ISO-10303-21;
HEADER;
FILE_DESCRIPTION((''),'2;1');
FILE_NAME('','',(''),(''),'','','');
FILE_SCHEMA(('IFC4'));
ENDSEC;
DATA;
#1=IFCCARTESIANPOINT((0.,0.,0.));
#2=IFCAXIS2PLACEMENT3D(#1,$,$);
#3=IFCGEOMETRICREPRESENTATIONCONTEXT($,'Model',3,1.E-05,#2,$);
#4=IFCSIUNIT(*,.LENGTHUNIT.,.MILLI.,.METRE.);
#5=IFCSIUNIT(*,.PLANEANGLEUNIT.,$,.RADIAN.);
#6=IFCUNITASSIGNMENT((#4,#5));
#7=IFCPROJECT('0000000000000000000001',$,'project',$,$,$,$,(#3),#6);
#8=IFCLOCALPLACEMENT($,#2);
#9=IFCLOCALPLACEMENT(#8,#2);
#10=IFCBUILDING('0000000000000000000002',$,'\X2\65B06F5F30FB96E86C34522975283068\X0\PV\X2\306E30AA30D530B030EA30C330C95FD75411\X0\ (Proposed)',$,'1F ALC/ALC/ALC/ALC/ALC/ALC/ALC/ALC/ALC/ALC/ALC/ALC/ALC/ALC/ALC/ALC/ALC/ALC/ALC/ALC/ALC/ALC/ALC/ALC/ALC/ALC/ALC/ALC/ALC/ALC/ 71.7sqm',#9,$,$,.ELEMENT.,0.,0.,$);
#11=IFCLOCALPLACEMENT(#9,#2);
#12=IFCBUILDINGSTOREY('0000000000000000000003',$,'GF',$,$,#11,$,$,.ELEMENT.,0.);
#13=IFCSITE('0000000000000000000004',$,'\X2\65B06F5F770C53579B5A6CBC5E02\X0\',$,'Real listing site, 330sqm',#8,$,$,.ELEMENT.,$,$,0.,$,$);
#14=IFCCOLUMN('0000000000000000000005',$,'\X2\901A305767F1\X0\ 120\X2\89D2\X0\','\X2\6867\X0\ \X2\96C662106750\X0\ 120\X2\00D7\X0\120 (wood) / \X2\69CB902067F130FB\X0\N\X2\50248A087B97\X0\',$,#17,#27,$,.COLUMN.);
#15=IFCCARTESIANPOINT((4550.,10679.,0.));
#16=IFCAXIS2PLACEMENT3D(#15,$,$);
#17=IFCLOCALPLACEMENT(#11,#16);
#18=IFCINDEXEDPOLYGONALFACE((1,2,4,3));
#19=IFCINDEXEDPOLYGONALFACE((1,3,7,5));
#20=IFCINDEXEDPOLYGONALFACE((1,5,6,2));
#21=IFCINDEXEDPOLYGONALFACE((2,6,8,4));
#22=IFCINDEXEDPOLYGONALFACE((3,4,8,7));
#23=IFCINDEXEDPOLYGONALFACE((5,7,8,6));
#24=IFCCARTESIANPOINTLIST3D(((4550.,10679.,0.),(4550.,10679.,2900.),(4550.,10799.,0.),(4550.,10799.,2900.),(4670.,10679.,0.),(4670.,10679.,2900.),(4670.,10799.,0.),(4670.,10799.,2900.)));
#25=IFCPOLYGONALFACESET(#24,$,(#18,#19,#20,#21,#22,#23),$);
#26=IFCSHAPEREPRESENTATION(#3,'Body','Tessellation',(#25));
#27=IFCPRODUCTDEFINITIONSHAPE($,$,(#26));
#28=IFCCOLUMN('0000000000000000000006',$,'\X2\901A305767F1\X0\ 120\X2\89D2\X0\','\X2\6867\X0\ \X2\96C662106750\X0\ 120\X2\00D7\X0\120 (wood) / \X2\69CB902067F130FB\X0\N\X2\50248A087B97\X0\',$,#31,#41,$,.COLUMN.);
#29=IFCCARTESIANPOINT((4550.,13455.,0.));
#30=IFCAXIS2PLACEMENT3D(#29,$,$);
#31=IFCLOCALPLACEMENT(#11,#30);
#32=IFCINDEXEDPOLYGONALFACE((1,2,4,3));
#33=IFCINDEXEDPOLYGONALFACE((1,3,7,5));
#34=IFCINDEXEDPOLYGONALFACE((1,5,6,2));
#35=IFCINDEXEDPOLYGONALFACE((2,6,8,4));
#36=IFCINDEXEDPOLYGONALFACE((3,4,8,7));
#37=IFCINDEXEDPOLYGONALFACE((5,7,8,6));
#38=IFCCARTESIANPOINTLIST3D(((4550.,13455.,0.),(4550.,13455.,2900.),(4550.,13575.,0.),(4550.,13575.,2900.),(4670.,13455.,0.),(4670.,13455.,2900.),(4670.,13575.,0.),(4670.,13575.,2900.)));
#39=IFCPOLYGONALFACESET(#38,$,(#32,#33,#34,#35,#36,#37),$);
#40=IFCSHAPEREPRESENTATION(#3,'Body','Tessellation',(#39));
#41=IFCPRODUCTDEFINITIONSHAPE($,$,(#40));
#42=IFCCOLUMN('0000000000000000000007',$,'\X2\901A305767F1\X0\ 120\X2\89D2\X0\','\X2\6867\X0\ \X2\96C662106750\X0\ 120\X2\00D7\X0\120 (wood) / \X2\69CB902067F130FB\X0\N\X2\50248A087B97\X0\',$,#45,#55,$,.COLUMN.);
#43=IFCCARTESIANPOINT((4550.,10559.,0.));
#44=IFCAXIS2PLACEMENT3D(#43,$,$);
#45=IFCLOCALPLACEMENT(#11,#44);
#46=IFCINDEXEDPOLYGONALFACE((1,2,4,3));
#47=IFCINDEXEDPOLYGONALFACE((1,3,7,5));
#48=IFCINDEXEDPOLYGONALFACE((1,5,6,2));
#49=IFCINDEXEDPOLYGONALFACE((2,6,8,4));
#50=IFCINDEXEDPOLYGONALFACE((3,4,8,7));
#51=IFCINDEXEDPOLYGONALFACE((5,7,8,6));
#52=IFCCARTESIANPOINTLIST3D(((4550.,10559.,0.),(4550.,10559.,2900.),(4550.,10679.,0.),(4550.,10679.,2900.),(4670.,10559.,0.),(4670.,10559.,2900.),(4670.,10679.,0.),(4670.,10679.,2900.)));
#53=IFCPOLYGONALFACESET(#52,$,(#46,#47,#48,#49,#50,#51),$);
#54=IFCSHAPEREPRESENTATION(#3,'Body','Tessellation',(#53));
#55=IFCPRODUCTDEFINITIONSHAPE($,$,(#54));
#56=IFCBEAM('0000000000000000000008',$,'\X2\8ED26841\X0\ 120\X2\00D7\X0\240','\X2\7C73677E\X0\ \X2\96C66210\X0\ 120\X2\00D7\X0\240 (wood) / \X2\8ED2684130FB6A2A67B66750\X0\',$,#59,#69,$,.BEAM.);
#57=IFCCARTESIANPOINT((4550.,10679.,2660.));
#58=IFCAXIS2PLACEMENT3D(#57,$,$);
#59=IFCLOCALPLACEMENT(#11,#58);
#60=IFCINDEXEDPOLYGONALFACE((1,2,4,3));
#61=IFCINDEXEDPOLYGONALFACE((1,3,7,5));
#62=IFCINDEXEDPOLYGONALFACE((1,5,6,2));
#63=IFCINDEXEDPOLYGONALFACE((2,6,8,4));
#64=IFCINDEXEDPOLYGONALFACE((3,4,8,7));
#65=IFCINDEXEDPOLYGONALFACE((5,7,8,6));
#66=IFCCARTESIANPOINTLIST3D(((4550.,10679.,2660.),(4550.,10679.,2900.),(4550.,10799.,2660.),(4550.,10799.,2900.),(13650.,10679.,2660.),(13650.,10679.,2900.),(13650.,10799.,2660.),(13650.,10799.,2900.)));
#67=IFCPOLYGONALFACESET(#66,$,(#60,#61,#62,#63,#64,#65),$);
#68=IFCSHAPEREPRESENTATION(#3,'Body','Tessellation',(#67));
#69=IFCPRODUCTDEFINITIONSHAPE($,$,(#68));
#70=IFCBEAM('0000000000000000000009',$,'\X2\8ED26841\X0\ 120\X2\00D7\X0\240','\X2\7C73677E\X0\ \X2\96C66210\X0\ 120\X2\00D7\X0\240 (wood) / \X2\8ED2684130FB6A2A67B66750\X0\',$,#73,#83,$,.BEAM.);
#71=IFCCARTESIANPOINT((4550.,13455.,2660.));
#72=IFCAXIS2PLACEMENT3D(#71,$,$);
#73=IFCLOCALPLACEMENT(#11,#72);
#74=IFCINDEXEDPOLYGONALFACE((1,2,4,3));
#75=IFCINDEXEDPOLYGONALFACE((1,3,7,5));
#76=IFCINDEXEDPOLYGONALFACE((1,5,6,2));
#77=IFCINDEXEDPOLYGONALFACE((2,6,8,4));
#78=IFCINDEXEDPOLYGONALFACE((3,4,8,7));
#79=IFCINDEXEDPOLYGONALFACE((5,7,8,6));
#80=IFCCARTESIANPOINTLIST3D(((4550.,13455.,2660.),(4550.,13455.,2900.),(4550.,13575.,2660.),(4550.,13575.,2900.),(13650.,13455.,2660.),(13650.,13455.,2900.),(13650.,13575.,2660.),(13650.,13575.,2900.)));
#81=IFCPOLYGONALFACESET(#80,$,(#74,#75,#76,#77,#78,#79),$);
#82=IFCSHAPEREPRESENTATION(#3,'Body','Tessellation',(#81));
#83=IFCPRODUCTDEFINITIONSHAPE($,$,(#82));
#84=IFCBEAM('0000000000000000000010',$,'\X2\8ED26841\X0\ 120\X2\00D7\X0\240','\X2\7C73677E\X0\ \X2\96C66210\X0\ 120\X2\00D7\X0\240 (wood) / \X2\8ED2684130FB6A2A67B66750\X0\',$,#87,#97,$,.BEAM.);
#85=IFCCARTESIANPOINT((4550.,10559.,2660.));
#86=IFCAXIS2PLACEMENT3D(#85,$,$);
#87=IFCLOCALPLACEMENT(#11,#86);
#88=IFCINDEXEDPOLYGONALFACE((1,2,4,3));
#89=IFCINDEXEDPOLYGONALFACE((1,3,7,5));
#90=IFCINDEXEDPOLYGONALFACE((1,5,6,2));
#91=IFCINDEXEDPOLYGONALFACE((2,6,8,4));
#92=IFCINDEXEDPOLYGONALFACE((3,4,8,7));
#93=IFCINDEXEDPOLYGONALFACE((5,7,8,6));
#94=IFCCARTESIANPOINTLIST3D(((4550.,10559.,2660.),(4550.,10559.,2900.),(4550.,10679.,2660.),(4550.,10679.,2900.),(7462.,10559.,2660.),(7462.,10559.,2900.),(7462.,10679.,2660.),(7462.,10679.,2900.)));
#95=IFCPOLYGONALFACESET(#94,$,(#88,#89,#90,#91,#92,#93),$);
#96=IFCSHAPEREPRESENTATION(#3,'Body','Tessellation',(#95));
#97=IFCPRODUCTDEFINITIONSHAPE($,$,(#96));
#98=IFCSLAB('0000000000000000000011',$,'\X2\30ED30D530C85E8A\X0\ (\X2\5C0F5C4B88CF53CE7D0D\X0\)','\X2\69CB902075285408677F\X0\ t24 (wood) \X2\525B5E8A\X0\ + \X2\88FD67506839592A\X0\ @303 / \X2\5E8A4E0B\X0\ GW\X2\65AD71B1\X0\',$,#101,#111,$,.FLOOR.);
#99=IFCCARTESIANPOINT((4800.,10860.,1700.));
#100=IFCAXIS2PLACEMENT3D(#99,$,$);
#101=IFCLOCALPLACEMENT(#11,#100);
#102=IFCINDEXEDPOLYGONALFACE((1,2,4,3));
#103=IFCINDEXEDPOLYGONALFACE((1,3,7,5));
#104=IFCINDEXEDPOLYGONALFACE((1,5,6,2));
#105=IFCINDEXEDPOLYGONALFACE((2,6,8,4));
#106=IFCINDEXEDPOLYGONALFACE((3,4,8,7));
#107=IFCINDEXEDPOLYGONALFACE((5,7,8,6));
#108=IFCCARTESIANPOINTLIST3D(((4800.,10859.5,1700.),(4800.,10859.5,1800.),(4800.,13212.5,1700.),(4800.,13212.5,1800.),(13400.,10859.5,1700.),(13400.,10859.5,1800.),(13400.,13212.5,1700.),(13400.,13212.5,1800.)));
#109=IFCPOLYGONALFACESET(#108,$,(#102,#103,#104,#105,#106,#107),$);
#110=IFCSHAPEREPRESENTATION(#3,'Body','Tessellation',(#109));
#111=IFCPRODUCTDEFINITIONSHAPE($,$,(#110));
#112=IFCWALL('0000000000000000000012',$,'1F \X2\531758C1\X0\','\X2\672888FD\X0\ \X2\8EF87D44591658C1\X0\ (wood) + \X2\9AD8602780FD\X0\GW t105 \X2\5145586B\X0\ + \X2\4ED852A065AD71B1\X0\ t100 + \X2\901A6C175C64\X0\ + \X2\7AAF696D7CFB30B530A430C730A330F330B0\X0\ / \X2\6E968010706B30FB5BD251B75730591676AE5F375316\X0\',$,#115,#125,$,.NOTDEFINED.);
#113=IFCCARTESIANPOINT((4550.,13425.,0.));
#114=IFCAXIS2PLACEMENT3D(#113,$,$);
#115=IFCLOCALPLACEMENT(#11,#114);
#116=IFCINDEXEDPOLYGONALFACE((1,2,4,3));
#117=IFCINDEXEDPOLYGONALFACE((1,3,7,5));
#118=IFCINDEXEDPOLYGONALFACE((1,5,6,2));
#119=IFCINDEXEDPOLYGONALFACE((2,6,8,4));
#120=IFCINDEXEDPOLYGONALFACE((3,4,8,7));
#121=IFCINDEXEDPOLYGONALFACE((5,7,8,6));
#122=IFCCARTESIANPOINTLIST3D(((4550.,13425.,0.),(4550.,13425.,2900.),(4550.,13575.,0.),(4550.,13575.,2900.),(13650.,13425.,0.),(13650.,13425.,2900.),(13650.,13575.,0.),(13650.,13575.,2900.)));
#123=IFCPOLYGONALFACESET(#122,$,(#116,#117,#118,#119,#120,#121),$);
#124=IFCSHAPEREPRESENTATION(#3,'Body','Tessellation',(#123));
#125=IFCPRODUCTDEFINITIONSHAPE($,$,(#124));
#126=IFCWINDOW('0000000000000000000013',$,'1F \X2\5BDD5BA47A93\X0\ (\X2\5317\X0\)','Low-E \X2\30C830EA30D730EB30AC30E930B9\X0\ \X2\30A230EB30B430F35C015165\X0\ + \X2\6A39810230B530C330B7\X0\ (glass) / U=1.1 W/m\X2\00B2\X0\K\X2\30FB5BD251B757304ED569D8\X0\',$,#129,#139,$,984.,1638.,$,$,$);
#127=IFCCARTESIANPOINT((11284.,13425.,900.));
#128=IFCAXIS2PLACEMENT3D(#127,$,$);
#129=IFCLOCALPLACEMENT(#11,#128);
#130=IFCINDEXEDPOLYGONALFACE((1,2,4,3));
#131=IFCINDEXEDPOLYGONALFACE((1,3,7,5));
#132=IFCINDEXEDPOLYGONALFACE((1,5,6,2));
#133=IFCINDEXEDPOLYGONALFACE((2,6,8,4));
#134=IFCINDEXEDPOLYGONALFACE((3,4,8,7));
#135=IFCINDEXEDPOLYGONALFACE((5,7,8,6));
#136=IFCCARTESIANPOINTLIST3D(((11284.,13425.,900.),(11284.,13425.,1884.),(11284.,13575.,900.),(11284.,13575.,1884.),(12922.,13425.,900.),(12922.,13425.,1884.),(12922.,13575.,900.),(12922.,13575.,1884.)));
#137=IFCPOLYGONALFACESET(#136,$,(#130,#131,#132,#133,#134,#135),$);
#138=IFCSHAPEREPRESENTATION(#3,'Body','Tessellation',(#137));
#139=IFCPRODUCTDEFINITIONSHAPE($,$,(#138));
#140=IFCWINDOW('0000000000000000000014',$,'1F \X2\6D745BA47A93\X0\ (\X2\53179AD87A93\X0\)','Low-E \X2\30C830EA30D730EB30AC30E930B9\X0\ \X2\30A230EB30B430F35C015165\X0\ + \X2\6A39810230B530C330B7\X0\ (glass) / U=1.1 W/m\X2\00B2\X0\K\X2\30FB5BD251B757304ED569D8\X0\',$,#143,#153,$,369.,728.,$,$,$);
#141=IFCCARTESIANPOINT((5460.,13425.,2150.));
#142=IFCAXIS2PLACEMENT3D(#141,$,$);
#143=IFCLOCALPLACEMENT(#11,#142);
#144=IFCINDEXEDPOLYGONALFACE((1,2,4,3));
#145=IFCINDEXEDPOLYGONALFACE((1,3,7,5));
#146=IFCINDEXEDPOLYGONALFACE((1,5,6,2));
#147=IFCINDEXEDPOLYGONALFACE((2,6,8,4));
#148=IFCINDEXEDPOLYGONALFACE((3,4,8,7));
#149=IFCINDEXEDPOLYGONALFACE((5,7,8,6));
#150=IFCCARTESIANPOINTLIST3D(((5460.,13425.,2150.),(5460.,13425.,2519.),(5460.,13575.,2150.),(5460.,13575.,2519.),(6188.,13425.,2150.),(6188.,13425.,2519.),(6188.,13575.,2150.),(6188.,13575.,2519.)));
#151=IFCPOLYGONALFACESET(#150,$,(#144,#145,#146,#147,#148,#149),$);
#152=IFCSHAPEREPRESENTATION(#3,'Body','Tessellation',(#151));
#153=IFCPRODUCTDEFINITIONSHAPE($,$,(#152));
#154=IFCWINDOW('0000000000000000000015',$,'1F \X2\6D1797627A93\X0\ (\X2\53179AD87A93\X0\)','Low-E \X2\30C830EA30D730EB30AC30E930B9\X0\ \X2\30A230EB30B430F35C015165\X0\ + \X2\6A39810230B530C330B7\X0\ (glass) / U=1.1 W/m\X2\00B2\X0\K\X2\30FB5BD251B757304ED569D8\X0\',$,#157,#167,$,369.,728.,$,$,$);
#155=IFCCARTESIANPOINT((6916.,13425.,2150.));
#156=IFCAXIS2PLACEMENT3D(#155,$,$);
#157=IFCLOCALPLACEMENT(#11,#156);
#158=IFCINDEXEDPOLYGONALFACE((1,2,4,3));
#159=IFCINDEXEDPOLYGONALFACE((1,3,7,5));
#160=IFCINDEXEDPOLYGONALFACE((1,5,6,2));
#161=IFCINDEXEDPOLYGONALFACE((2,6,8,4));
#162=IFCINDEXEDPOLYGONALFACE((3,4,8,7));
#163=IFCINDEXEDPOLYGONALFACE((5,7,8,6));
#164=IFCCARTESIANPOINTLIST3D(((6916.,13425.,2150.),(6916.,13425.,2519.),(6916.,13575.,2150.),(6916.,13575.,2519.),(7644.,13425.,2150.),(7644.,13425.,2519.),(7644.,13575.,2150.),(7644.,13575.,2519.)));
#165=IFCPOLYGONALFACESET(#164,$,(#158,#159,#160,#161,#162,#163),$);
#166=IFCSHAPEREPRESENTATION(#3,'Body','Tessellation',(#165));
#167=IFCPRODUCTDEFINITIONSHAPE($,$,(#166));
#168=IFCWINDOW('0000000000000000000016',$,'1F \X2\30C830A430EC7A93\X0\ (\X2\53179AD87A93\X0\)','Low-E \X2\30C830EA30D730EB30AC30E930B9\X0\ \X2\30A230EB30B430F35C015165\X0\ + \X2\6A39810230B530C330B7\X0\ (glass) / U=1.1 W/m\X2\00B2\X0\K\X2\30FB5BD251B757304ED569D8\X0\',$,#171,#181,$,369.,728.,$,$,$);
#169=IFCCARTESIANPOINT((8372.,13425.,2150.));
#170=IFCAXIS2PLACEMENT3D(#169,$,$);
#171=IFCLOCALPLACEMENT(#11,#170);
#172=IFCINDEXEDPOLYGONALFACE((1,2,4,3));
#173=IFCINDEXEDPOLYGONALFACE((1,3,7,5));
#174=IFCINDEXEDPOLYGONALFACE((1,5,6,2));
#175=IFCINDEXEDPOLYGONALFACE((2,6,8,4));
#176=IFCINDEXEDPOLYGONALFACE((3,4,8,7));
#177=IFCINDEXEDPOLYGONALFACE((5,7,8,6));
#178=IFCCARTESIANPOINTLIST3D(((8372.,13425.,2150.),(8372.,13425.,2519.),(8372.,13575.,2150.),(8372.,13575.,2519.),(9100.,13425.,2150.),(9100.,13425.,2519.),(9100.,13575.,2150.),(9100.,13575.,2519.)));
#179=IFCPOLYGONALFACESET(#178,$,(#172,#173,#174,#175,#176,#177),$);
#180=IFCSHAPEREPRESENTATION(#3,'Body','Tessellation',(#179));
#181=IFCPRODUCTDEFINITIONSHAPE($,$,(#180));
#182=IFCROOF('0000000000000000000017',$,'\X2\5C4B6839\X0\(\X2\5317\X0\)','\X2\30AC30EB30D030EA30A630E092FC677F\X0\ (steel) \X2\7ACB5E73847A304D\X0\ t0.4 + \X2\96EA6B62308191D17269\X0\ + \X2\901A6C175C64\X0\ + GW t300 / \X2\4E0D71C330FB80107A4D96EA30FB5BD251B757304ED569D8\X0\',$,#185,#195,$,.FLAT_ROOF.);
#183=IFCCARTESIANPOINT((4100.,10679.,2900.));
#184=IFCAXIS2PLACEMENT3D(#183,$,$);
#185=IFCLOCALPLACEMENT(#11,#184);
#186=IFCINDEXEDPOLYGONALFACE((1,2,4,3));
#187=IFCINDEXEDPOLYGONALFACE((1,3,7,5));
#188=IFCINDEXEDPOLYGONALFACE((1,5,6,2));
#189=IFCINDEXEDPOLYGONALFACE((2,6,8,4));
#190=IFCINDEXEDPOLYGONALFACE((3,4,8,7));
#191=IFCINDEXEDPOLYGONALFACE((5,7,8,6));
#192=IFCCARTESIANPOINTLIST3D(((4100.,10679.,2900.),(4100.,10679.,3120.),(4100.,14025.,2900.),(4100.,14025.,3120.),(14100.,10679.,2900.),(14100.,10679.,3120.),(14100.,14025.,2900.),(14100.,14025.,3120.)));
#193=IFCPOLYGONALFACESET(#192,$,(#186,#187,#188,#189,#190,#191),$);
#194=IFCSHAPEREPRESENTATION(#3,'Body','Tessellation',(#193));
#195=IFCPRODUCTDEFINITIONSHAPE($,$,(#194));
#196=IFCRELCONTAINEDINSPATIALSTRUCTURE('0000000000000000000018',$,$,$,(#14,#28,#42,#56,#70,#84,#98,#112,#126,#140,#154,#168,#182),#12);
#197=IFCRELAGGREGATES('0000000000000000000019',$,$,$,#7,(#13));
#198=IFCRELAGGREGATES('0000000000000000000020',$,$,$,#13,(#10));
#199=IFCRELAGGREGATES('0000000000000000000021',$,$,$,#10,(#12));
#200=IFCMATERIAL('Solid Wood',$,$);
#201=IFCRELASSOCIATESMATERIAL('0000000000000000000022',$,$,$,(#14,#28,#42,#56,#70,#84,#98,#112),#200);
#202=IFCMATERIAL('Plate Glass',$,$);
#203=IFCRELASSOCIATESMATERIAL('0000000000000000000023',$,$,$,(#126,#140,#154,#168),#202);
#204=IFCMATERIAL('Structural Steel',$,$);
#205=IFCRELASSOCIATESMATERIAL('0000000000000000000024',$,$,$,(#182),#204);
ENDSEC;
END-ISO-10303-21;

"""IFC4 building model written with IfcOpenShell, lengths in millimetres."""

from ifc_helpers import new_model, si_unit, frame, frame_2d, origin, place, context, project, spatial, rectangle, extrude, material, element, fill, save


model = new_model("IFC4")

# Units and contexts
model_context = context("Model", 3, precision=1e-05, world=origin())
ifc_project = project(units=[si_unit("LENGTHUNIT", "METRE", prefix="MILLI"), si_unit("PLANEANGLEUNIT", "RADIAN")], contexts=[model_context])

# Site, building, storey
site_placement = place(None, origin())
site = spatial("IfcSite", under=ifc_project, at=site_placement, Name="新潟県南魚沼市", ObjectType="Real listing site, 330sqm", CompositionType="ELEMENT", RefElevation=0.0)
building_placement = place(site_placement, origin())
building = spatial("IfcBuilding", under=site, at=building_placement, Name="新潟・雨水利用とPVのオフグリッド志向 (Proposed)", ObjectType="1F ALC/ALC/ALC/ALC/ALC/ALC/ALC/ALC/ALC/ALC/ALC/ALC/ALC/ALC/ALC/ALC/ALC/ALC/ALC/ALC/ALC/ALC/ALC/ALC/ALC/ALC/ALC/ALC/ALC/ALC/ 71.7sqm", CompositionType="ELEMENT", ElevationOfRefHeight=0.0, ElevationOfTerrain=0.0)
storey_placement = place(building_placement, origin())
storey = spatial("IfcBuildingStorey", under=building, at=storey_placement, Name="GF", CompositionType="ELEMENT", Elevation=0.0)

# Columns
ifc_material_1 = material(Name="Solid Wood")
column_1_placement = place(storey_placement, frame((4550.0, 10679.0, 0.0)))
element("IfcColumn", 1, at=column_1_placement, inside=storey, material=ifc_material_1, Name="通し柱 120角", Description="桧 集成材 120×120 (wood) / 構造柱・N値計算", PredefinedType="COLUMN", context=model_context, shape_type="SweptSolid", body=[
    extrude(rectangle(XDim=120.0, YDim=120.0, at=frame_2d((60.0, 60.0))), frame((4550.0, 10679.0, 0.0)), (0.0, 0.0, 1.0), 2900.0),
])
column_2_placement = place(storey_placement, frame((4550.0, 13455.0, 0.0)))
element("IfcColumn", 2, at=column_2_placement, inside=storey, material=ifc_material_1, Name="通し柱 120角", Description="桧 集成材 120×120 (wood) / 構造柱・N値計算", PredefinedType="COLUMN", context=model_context, shape_type="SweptSolid", body=[
    extrude(rectangle(XDim=120.0, YDim=120.0, at=frame_2d((60.0, 60.0))), frame((4550.0, 13455.0, 0.0)), (0.0, 0.0, 1.0), 2900.0),
])
column_3_placement = place(storey_placement, frame((4550.0, 10559.0, 0.0)))
element("IfcColumn", 3, at=column_3_placement, inside=storey, material=ifc_material_1, Name="通し柱 120角", Description="桧 集成材 120×120 (wood) / 構造柱・N値計算", PredefinedType="COLUMN", context=model_context, shape_type="SweptSolid", body=[
    extrude(rectangle(XDim=120.0, YDim=120.0, at=frame_2d((60.0, 60.0))), frame((4550.0, 10559.0, 0.0)), (0.0, 0.0, 1.0), 2900.0),
])

# Beams
beam_1_placement = place(storey_placement, frame((4550.0, 10679.0, 2660.0)))
element("IfcBeam", 4, at=beam_1_placement, inside=storey, material=ifc_material_1, Name="軒桁 120×240", Description="米松 集成 120×240 (wood) / 軒桁・横架材", PredefinedType="BEAM", context=model_context, shape_type="SweptSolid", body=[
    extrude(rectangle(XDim=9100.0, YDim=120.0, at=frame_2d((4550.0, 60.0))), frame((4550.0, 10679.0, 2660.0)), (0.0, 0.0, 1.0), 240.0),
])
beam_2_placement = place(storey_placement, frame((4550.0, 13455.0, 2660.0)))
element("IfcBeam", 5, at=beam_2_placement, inside=storey, material=ifc_material_1, Name="軒桁 120×240", Description="米松 集成 120×240 (wood) / 軒桁・横架材", PredefinedType="BEAM", context=model_context, shape_type="SweptSolid", body=[
    extrude(rectangle(XDim=9100.0, YDim=120.0, at=frame_2d((4550.0, 60.0))), frame((4550.0, 13455.0, 2660.0)), (0.0, 0.0, 1.0), 240.0),
])
beam_3_placement = place(storey_placement, frame((4550.0, 10559.0, 2660.0)))
element("IfcBeam", 6, at=beam_3_placement, inside=storey, material=ifc_material_1, Name="軒桁 120×240", Description="米松 集成 120×240 (wood) / 軒桁・横架材", PredefinedType="BEAM", context=model_context, shape_type="SweptSolid", body=[
    extrude(rectangle(XDim=2912.0, YDim=120.0, at=frame_2d((1456.0, 60.0))), frame((4550.0, 10559.0, 2660.0)), (0.0, 0.0, 1.0), 240.0),
])

# Slab
slab_1_placement = place(storey_placement, frame((4800.0, 10860.0, 1700.0)))
element("IfcSlab", 7, at=slab_1_placement, inside=storey, material=ifc_material_1, Name="ロフト床 (小屋裏収納)", Description="構造用合板 t24 (wood) 剛床 + 製材根太 @303 / 床下 GW断熱", PredefinedType="FLOOR", context=model_context, shape_type="SweptSolid", body=[
    extrude(rectangle(XDim=8600.0, YDim=2353.0, at=frame_2d((4300.0, 1176.0))), frame((4800.0, 10860.0, 1700.0)), (0.0, 0.0, 1.0), 100.0),
])

# Wall, openings, windows
wall_1_placement = place(storey_placement, frame((4550.0, 13425.0, 0.0)))
wall_1 = element("IfcWall", 8, at=wall_1_placement, inside=storey, material=ifc_material_1, Name="1F 北壁", Description="木製 軸組外壁 (wood) + 高性能GW t105 充填 + 付加断熱 t100 + 通気層 + 窯業系サイディング / 準耐火・寒冷地外皮強化", PredefinedType="NOTDEFINED", context=model_context, shape_type="SweptSolid", body=[
    extrude(rectangle(XDim=9100.0, YDim=150.0, at=frame_2d((4550.0, 75.0))), frame((4550.0, 13425.0, 0.0)), (0.0, 0.0, 1.0), 2900.0),
])
opening_1_placement = place(storey_placement, frame((11284.0, 13425.0, 900.0)))
opening_1 = element("IfcOpeningElement", 9, at=opening_1_placement, cuts=wall_1, PredefinedType="NOTDEFINED", context=model_context, shape_type="SweptSolid", body=[
    extrude(rectangle(XDim=1638.0, YDim=150.0, at=frame_2d((819.0, 75.0))), frame((11284.0, 13425.0, 900.0)), (0.0, 0.0, 1.0), 984.0),
])
opening_2_placement = place(storey_placement, frame((5460.0, 13425.0, 2150.0)))
opening_2 = element("IfcOpeningElement", 10, at=opening_2_placement, cuts=wall_1, PredefinedType="NOTDEFINED", context=model_context, shape_type="SweptSolid", body=[
    extrude(rectangle(XDim=728.0, YDim=150.0, at=frame_2d((364.0, 75.0))), frame((5460.0, 13425.0, 2150.0)), (0.0, 0.0, 1.0), 369.0),
])
opening_3_placement = place(storey_placement, frame((6916.0, 13425.0, 2150.0)))
opening_3 = element("IfcOpeningElement", 11, at=opening_3_placement, cuts=wall_1, PredefinedType="NOTDEFINED", context=model_context, shape_type="SweptSolid", body=[
    extrude(rectangle(XDim=728.0, YDim=150.0, at=frame_2d((364.0, 75.0))), frame((6916.0, 13425.0, 2150.0)), (0.0, 0.0, 1.0), 369.0),
])
opening_4_placement = place(storey_placement, frame((8372.0, 13425.0, 2150.0)))
opening_4 = element("IfcOpeningElement", 12, at=opening_4_placement, cuts=wall_1, PredefinedType="NOTDEFINED", context=model_context, shape_type="SweptSolid", body=[
    extrude(rectangle(XDim=728.0, YDim=150.0, at=frame_2d((364.0, 75.0))), frame((8372.0, 13425.0, 2150.0)), (0.0, 0.0, 1.0), 369.0),
])
ifc_material_2 = material(Name="Plate Glass")
window_1_placement = place(storey_placement, frame((11284.0, 13425.0, 900.0)))
window_1 = element("IfcWindow", 13, at=window_1_placement, inside=storey, material=ifc_material_2, Name="1F 寝室窓 (北)", Description="Low-E トリプルガラス アルゴン封入 + 樹脂サッシ (glass) / U=1.1 W/m²K・寒冷地仕様", OverallHeight=984.0, OverallWidth=1638.0, context=model_context, shape_type="SweptSolid", body=[
    extrude(rectangle(XDim=1638.0, YDim=150.0, at=frame_2d((819.0, 75.0))), frame((11284.0, 13425.0, 900.0)), (0.0, 0.0, 1.0), 984.0),
])
fill(opening_1, window_1)
window_2_placement = place(storey_placement, frame((5460.0, 13425.0, 2150.0)))
window_2 = element("IfcWindow", 14, at=window_2_placement, inside=storey, material=ifc_material_2, Name="1F 浴室窓 (北高窓)", Description="Low-E トリプルガラス アルゴン封入 + 樹脂サッシ (glass) / U=1.1 W/m²K・寒冷地仕様", OverallHeight=369.0, OverallWidth=728.0, context=model_context, shape_type="SweptSolid", body=[
    extrude(rectangle(XDim=728.0, YDim=150.0, at=frame_2d((364.0, 75.0))), frame((5460.0, 13425.0, 2150.0)), (0.0, 0.0, 1.0), 369.0),
])
fill(opening_2, window_2)
window_3_placement = place(storey_placement, frame((6916.0, 13425.0, 2150.0)))
window_3 = element("IfcWindow", 15, at=window_3_placement, inside=storey, material=ifc_material_2, Name="1F 洗面窓 (北高窓)", Description="Low-E トリプルガラス アルゴン封入 + 樹脂サッシ (glass) / U=1.1 W/m²K・寒冷地仕様", OverallHeight=369.0, OverallWidth=728.0, context=model_context, shape_type="SweptSolid", body=[
    extrude(rectangle(XDim=728.0, YDim=150.0, at=frame_2d((364.0, 75.0))), frame((6916.0, 13425.0, 2150.0)), (0.0, 0.0, 1.0), 369.0),
])
fill(opening_3, window_3)
window_4_placement = place(storey_placement, frame((8372.0, 13425.0, 2150.0)))
window_4 = element("IfcWindow", 16, at=window_4_placement, inside=storey, material=ifc_material_2, Name="1F トイレ窓 (北高窓)", Description="Low-E トリプルガラス アルゴン封入 + 樹脂サッシ (glass) / U=1.1 W/m²K・寒冷地仕様", OverallHeight=369.0, OverallWidth=728.0, context=model_context, shape_type="SweptSolid", body=[
    extrude(rectangle(XDim=728.0, YDim=150.0, at=frame_2d((364.0, 75.0))), frame((8372.0, 13425.0, 2150.0)), (0.0, 0.0, 1.0), 369.0),
])
fill(opening_4, window_4)

# Roof
ifc_material_3 = material(Name="Structural Steel")
roof_placement = place(storey_placement, frame((4100.0, 10679.0, 2900.0)))
element("IfcRoof", 17, at=roof_placement, inside=storey, material=ifc_material_3, Name="屋根(北)", Description="ガルバリウム鋼板 (steel) 立平葺き t0.4 + 雪止め金物 + 通気層 + GW t300 / 不燃・耐積雪・寒冷地仕様", PredefinedType="FLAT_ROOF", context=model_context, shape_type="SweptSolid", body=[
    extrude(rectangle(XDim=10000.0, YDim=3346.0, at=frame_2d((5000.0, 1673.0))), frame((4100.0, 10679.0, 2900.0)), (0.0, 0.0, 1.0), 220.0),
])

save(model, "model.ifc")
